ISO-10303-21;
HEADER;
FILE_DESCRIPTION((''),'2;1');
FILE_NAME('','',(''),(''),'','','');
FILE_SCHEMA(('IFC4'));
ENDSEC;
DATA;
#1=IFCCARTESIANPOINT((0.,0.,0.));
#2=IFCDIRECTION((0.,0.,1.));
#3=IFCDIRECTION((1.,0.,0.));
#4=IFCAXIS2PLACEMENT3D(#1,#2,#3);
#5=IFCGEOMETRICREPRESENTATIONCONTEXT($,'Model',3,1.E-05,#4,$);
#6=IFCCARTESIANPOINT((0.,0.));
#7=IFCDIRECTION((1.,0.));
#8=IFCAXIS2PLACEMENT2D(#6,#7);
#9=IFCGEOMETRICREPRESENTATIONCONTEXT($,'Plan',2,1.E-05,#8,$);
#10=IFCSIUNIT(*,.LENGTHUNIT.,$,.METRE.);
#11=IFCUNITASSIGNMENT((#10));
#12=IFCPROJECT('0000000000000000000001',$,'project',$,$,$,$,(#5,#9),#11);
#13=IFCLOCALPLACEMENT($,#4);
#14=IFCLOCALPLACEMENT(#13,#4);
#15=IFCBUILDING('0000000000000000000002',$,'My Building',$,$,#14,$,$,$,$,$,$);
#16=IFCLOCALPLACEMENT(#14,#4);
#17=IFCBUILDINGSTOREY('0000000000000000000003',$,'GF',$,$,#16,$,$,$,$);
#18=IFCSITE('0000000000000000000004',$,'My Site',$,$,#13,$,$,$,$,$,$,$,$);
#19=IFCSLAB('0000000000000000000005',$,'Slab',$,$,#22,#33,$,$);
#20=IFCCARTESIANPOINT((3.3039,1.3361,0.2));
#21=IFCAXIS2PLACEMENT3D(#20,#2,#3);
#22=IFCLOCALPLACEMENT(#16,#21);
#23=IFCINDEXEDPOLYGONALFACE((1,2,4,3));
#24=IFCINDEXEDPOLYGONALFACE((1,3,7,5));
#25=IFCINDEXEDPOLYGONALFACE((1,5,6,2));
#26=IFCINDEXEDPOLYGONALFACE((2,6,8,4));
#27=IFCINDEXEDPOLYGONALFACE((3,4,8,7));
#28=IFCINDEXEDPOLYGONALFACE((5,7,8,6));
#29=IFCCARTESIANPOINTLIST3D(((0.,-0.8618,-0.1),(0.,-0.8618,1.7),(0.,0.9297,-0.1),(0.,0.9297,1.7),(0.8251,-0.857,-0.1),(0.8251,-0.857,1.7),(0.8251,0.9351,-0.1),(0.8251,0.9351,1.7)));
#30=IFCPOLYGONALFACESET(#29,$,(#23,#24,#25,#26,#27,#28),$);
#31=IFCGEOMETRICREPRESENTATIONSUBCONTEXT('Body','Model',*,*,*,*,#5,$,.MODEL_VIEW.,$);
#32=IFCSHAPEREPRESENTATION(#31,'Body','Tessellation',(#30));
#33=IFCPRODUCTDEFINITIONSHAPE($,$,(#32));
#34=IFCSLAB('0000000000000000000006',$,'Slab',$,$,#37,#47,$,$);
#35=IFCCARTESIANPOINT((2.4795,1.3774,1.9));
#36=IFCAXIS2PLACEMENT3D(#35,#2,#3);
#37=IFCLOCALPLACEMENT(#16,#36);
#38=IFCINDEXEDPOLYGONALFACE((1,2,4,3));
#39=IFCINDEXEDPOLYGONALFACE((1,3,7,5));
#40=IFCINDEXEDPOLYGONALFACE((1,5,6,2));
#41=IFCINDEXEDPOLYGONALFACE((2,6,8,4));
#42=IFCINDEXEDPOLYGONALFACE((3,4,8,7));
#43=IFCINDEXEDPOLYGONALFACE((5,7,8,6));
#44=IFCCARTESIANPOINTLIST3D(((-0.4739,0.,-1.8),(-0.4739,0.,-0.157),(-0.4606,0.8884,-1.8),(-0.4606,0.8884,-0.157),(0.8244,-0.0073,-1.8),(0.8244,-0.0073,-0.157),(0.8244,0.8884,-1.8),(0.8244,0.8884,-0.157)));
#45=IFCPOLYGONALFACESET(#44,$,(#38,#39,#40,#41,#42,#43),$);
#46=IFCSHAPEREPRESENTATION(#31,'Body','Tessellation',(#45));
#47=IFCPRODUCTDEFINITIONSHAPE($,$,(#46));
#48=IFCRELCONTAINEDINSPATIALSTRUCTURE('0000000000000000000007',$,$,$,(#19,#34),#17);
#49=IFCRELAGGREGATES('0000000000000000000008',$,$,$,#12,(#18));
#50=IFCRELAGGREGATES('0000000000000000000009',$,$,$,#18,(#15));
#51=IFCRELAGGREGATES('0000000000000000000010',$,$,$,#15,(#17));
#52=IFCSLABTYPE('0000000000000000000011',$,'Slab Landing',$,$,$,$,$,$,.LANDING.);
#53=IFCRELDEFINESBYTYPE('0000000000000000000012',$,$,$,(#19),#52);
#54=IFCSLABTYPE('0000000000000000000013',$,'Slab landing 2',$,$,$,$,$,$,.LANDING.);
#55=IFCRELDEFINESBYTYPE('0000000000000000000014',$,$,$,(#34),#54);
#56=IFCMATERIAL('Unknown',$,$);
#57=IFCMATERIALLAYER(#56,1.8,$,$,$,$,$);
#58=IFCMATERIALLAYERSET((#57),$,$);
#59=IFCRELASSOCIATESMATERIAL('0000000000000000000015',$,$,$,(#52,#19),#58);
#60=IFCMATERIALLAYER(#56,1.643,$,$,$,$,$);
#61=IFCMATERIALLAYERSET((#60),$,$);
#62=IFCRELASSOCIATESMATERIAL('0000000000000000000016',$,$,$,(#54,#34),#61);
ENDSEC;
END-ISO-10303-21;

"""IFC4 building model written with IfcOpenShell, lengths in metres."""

from ifc_helpers import new_model, si_unit, frame, origin_with_axes, origin_2d_with_axis, place, context, subcontext, project, spatial, indexed_curve, outline, extrude, material, layer, layer_set, layer_usage, type_object, element, save


model = new_model("IFC4")

# Units and contexts
model_context = context("Model", 3, precision=1e-05, world=origin_with_axes())
plan_context = context("Plan", 2, precision=1e-05, world=origin_2d_with_axis())
body_context_1 = subcontext(model_context, "Body", "Model", "MODEL_VIEW")
ifc_project = project(units=[si_unit("LENGTHUNIT", "METRE")], contexts=[model_context, plan_context])

# Site, building, storey
site_placement = place(None, origin_with_axes())
site = spatial("IfcSite", under=ifc_project, at=site_placement, Name="My Site")
building_placement = place(site_placement, origin_with_axes())
building = spatial("IfcBuilding", under=site, at=building_placement, Name="My Building")
storey_placement = place(building_placement, origin_with_axes())
storey = spatial("IfcBuildingStorey", under=building, at=storey_placement, Name="GF")

# Shared definitions
ifc_material = material(Name="Unknown")

# Slabs
ifc_layer_1 = layer(ifc_material, 1.8)
ifc_layer_set_1 = layer_set([ifc_layer_1])
ifc_layer_usage_1 = layer_usage(ifc_layer_set_1, "AXIS3", "POSITIVE", -0.1)
slab_type_1 = type_object("IfcSlabType", Name="Slab Landing", PredefinedType="LANDING", material=ifc_layer_set_1)
slab_1_placement = place(storey_placement, frame((3.3039, 1.3361, 0.2), z_axis=(0.0, 0.0, 1.0), x_axis=(1.0, 0.0, 0.0)))
element("IfcSlab", 1, at=slab_1_placement, inside=storey, type_object=slab_type_1, material=ifc_layer_usage_1, Name="Slab", context=body_context_1, shape_type="SweptSolid", body=[
    extrude(outline(indexed_curve([(0.8251, 0.9351), (0.8251, -0.857), (0.0, -0.8618), (0.0, 0.9297), (0.8251, 0.9351)])), frame((0.0, 0.0, -0.1), z_axis=(0.0, 0.0, 1.0), x_axis=(1.0, 0.0, 0.0)), (0.0, 0.0, 1.0), 1.8),
])
ifc_layer_2 = layer(ifc_material, 1.643)
ifc_layer_set_2 = layer_set([ifc_layer_2])
ifc_layer_usage_2 = layer_usage(ifc_layer_set_2, "AXIS3", "POSITIVE", -1.8)
slab_type_2 = type_object("IfcSlabType", Name="Slab landing 2", PredefinedType="LANDING", material=ifc_layer_set_2)
slab_2_placement = place(storey_placement, frame((2.4795, 1.3774, 1.9), z_axis=(0.0, 0.0, 1.0), x_axis=(1.0, 0.0, 0.0)))
element("IfcSlab", 2, at=slab_2_placement, inside=storey, type_object=slab_type_2, material=ifc_layer_usage_2, Name="Slab", context=body_context_1, shape_type="SweptSolid", body=[
    extrude(outline(indexed_curve([(-0.4606, 0.8884), (0.8244, 0.8884), (0.8244, -0.0073), (-0.4739, 0.0), (-0.4606, 0.8884)])), frame((0.0, 0.0, -1.8), z_axis=(0.0, 0.0, 1.0), x_axis=(1.0, 0.0, 0.0)), (0.0, 0.0, 1.0), 1.643),
])

save(model, "model.ifc")
